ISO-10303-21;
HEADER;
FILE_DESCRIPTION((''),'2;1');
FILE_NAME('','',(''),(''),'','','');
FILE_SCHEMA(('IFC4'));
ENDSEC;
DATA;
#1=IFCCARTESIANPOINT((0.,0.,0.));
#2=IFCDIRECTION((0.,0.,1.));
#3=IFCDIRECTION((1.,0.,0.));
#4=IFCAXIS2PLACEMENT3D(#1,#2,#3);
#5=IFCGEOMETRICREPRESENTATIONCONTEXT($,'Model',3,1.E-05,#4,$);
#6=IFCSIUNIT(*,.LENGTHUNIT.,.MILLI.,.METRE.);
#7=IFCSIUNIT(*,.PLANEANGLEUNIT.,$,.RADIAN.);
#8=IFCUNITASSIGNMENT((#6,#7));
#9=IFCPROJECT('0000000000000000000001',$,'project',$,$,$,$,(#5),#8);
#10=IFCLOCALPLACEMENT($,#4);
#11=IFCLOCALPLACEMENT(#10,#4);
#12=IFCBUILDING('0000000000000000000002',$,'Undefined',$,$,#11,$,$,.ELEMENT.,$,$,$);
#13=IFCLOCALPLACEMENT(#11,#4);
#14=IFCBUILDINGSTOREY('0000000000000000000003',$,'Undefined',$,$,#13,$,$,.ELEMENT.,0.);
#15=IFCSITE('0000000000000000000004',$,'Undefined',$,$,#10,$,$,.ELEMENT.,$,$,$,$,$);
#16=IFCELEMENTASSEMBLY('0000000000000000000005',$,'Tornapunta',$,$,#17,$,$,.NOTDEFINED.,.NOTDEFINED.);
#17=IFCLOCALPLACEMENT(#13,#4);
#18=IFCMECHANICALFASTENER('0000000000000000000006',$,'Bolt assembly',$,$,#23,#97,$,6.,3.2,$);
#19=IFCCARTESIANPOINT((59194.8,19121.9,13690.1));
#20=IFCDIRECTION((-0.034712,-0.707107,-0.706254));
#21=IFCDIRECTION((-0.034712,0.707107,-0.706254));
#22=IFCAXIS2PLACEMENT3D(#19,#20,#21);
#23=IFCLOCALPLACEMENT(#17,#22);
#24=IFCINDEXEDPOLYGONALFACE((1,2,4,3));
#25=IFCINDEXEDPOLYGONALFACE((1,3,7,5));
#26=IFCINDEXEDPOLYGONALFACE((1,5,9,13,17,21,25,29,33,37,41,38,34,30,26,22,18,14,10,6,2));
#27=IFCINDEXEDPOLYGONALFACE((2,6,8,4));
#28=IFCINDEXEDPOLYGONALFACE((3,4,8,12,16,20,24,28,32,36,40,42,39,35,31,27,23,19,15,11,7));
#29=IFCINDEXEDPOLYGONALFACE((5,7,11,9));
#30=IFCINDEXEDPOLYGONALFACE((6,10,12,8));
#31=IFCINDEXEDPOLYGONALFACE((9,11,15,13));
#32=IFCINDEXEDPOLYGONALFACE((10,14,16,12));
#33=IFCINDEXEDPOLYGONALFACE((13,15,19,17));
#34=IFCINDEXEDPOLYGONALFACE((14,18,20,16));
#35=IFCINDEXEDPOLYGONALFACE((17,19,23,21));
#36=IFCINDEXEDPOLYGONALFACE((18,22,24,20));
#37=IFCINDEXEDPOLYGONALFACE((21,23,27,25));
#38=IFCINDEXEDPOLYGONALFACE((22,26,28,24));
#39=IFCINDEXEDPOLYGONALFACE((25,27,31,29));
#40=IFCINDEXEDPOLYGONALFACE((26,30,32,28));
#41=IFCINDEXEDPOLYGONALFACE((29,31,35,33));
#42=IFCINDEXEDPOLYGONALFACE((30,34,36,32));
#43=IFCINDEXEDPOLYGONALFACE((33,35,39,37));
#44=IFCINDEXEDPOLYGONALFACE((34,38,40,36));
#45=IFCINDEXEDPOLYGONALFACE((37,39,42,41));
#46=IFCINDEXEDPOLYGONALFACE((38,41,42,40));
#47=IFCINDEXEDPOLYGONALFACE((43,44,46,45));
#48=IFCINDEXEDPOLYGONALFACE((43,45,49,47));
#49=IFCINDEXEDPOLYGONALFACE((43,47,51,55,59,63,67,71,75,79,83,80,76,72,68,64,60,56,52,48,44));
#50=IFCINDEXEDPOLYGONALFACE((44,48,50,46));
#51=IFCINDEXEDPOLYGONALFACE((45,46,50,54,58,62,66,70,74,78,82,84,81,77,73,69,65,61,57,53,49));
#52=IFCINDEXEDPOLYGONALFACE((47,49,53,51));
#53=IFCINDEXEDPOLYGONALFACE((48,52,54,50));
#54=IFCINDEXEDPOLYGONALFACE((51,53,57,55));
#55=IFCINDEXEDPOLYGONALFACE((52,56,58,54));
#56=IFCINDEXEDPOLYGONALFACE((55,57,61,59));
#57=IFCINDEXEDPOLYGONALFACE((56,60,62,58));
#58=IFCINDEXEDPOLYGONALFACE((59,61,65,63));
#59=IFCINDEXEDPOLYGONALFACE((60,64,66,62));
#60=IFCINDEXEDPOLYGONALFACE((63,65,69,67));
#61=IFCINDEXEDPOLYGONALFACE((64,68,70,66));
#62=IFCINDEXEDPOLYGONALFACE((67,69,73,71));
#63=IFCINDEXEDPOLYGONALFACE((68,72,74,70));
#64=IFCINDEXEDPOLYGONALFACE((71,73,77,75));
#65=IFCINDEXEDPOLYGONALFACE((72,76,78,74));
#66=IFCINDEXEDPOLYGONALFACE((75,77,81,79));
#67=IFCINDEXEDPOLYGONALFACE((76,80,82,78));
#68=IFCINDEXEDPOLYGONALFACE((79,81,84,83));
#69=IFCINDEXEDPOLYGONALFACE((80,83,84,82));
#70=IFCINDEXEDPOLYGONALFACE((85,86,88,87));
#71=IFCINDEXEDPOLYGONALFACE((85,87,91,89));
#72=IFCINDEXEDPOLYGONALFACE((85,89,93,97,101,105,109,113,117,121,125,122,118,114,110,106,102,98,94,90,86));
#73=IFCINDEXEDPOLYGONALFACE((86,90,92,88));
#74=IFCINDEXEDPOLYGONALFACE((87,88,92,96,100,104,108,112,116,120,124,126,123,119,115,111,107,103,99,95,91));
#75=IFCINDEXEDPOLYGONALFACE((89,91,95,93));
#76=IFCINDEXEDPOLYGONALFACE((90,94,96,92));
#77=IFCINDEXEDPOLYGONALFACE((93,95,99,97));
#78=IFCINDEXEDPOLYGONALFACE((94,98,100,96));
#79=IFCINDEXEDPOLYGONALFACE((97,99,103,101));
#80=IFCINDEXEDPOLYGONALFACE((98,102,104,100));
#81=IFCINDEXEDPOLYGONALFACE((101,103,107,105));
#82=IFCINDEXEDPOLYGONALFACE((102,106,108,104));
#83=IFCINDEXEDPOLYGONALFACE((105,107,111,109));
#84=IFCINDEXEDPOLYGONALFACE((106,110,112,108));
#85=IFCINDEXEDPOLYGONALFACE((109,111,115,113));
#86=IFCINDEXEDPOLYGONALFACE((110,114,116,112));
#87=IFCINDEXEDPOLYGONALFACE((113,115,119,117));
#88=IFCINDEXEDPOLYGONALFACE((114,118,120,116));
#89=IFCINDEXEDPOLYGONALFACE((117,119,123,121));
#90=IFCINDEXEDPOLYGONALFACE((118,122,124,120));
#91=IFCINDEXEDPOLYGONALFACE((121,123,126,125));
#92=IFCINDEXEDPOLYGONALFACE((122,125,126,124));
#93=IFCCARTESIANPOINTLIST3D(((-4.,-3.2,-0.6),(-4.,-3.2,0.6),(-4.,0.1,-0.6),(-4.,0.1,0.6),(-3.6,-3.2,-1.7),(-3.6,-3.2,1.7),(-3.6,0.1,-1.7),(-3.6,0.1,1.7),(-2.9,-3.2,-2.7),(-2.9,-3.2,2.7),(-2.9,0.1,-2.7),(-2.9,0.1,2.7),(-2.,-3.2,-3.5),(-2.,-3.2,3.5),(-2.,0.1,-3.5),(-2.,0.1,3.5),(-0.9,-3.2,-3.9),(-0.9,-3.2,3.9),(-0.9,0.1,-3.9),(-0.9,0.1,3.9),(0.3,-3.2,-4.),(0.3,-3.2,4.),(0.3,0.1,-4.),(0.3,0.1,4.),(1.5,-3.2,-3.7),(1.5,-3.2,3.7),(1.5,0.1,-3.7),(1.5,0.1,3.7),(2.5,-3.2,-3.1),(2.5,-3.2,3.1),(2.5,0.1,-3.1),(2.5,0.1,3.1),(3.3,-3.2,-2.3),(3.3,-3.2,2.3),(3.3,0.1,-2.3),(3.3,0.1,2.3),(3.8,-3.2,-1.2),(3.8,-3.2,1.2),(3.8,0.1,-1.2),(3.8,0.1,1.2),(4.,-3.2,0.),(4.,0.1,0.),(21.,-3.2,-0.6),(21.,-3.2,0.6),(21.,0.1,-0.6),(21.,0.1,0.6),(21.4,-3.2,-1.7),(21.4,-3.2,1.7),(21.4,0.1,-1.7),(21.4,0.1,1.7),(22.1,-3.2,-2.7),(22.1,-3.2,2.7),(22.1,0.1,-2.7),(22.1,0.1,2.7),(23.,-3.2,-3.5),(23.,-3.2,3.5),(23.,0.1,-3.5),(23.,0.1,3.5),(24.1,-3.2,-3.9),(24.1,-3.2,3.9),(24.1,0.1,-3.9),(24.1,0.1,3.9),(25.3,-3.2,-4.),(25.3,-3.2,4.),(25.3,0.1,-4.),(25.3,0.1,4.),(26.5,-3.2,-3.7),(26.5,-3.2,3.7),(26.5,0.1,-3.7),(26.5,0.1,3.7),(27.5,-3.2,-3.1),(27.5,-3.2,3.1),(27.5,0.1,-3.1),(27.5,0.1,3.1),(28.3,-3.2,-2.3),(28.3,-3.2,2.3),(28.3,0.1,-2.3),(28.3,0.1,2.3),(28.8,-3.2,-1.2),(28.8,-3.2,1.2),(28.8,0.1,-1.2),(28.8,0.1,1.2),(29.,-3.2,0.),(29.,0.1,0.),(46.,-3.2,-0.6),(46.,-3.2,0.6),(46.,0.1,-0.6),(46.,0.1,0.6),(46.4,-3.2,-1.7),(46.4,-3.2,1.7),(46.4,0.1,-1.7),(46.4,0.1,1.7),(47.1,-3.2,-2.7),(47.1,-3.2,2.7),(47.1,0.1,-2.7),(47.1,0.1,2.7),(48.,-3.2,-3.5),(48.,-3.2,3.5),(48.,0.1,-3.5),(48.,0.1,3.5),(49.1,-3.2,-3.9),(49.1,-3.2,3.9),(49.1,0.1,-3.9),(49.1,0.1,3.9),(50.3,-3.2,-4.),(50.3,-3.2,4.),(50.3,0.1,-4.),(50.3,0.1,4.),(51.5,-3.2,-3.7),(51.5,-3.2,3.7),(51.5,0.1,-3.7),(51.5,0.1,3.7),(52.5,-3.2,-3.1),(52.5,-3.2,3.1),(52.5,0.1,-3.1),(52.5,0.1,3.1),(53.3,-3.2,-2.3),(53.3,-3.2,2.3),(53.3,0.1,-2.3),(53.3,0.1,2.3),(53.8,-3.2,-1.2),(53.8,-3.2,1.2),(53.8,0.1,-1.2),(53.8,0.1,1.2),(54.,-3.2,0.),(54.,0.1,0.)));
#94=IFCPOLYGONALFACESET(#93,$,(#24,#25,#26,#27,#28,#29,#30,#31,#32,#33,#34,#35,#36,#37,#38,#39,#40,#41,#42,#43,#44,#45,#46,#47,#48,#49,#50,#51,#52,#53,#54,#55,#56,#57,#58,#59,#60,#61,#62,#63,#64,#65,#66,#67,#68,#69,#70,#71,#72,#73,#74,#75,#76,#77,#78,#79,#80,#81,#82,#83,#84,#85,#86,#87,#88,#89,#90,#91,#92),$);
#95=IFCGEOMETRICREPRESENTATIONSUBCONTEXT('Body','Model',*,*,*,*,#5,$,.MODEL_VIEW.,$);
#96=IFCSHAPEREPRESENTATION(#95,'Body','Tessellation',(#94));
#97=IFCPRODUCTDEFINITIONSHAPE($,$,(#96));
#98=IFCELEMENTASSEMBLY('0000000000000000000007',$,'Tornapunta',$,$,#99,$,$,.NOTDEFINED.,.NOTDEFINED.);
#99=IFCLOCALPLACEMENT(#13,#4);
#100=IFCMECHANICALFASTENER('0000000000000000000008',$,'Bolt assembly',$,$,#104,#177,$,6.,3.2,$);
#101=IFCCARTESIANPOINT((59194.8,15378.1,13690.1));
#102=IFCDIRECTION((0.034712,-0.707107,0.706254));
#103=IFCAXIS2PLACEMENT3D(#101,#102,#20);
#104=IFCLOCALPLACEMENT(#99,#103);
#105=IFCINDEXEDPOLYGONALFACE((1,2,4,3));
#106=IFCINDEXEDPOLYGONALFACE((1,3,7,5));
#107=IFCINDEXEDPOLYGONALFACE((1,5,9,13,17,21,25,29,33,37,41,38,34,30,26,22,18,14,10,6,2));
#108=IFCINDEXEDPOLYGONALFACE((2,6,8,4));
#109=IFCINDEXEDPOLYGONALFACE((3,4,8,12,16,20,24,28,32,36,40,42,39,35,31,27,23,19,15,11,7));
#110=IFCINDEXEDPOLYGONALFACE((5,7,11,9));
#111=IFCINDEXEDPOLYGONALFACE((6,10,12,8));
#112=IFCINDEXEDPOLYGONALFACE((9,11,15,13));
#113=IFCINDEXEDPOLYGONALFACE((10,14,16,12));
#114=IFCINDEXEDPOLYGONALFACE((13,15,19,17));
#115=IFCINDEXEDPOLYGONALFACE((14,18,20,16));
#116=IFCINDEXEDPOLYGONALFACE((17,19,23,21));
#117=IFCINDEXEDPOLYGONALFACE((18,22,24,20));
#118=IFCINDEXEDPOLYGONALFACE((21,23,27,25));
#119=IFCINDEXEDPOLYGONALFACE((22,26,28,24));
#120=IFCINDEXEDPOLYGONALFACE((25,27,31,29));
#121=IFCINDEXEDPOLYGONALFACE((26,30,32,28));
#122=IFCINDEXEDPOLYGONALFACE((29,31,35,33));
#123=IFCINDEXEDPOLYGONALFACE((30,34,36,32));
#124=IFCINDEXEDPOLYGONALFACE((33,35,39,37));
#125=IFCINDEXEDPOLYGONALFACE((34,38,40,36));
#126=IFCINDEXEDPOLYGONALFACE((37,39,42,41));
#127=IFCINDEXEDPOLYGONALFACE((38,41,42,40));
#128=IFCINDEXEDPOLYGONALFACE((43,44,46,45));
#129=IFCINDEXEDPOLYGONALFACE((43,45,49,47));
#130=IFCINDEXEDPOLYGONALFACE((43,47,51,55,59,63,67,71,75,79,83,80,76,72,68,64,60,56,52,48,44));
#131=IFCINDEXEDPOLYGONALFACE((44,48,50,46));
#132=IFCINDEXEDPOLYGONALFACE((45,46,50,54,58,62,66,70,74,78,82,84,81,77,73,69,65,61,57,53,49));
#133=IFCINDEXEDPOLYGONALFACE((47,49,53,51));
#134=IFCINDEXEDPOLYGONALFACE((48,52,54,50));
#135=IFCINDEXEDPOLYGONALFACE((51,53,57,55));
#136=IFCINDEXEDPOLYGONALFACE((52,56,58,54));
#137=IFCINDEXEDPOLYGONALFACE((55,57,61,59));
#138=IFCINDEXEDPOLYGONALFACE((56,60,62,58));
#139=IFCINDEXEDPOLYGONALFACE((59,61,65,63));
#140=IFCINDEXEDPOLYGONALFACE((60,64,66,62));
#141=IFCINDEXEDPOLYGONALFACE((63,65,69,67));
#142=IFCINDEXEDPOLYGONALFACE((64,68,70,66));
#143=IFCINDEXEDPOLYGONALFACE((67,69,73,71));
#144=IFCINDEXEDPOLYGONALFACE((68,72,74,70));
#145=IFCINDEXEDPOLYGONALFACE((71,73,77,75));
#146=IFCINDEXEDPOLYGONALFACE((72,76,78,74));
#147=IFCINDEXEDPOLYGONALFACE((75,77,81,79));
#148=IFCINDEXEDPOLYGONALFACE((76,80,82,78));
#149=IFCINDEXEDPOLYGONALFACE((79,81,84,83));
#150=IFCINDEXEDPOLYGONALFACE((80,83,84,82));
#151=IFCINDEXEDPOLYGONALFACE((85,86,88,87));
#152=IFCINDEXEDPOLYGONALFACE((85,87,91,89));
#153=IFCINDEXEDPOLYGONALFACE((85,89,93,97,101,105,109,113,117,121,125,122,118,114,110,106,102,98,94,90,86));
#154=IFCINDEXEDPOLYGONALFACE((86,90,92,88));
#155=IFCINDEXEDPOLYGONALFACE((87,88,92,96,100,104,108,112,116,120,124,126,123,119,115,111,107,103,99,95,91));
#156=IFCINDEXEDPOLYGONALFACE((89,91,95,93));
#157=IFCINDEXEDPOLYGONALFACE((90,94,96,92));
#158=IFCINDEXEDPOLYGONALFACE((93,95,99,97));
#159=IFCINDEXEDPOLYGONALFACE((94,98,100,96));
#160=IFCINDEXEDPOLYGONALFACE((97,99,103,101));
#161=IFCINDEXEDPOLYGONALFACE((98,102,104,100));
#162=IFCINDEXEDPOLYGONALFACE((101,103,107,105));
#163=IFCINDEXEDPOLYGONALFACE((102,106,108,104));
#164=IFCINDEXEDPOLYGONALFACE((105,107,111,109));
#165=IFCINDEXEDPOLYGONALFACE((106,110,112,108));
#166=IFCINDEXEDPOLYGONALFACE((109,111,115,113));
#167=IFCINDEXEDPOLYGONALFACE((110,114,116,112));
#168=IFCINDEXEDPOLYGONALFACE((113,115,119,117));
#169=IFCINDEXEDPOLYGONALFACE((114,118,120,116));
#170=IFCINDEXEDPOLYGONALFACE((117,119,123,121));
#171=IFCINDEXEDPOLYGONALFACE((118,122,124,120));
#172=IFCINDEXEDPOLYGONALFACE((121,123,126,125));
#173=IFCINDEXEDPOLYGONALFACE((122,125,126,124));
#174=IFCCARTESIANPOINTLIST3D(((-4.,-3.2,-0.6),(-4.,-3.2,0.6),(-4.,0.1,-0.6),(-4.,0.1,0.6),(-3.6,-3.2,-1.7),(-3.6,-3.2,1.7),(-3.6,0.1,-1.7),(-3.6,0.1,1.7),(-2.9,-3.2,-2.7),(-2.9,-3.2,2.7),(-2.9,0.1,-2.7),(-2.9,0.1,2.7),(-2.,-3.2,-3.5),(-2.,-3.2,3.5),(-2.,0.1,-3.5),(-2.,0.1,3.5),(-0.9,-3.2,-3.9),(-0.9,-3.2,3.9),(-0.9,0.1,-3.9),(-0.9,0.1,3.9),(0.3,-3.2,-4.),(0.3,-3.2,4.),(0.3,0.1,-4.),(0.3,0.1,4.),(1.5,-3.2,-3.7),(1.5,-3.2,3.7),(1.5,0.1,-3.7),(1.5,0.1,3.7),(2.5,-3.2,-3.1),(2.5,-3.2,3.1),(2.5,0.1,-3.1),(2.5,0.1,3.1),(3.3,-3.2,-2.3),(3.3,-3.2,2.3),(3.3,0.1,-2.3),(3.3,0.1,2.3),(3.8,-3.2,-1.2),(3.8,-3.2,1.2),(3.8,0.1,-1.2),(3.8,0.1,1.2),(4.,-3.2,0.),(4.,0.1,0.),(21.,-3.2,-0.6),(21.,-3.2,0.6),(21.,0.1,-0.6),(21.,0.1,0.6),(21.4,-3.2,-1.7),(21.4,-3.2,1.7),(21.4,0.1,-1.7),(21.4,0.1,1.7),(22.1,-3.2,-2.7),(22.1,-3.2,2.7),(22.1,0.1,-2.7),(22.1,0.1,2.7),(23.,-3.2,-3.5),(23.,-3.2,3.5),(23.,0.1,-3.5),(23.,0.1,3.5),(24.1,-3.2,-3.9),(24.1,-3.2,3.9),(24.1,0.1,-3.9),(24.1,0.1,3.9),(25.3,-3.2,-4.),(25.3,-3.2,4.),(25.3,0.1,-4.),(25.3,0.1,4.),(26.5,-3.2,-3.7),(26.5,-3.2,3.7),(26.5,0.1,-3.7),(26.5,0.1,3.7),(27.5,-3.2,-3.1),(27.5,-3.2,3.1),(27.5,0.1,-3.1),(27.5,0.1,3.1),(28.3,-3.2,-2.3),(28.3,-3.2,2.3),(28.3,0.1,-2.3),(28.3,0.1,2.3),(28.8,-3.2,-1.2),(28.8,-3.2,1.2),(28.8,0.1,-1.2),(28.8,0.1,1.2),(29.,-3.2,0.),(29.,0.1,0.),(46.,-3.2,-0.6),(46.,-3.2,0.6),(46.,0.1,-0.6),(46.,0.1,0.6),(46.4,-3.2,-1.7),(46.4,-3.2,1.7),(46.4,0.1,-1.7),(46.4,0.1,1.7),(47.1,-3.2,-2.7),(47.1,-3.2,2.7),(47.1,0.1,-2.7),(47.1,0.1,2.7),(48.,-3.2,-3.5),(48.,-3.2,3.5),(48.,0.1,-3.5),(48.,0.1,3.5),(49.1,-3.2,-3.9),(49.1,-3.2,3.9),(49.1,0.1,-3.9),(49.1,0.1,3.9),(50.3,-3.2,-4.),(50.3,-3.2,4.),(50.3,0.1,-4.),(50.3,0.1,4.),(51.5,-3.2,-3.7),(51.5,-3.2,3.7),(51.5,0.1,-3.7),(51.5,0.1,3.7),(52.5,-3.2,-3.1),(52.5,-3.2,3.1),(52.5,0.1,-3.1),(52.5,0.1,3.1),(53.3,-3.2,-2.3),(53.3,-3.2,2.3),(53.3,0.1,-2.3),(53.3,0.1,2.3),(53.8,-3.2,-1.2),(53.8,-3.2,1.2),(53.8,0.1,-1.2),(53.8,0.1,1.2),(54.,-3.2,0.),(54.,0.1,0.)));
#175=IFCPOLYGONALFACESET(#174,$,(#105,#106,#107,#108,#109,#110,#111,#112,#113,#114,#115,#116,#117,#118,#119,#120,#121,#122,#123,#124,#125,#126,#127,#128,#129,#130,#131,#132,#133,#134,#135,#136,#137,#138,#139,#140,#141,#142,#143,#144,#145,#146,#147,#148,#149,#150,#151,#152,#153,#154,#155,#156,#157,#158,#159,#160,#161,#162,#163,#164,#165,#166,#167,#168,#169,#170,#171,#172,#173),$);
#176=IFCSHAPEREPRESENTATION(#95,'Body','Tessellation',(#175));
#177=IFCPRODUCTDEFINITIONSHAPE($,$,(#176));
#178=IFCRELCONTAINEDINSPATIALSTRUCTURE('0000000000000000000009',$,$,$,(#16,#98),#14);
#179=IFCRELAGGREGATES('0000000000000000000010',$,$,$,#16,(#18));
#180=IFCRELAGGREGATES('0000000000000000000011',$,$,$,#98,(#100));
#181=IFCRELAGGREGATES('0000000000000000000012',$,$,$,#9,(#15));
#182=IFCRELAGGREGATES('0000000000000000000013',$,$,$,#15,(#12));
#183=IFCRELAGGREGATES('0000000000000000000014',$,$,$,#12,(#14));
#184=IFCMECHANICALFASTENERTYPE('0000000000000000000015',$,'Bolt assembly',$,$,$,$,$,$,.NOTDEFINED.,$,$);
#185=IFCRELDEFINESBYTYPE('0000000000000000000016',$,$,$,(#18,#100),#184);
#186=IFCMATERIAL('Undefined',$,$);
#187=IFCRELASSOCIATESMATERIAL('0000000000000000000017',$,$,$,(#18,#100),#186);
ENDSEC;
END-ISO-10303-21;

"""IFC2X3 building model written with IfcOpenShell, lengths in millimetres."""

from ifc_helpers import new_model, si_unit, frame, origin_with_axes, origin_2d_with_axis, place, context, subcontext, project, spatial, circle, extrude, source, transform, mapped, material, type_object, element, aggregate, save


model = new_model("IFC2X3")

# Units and contexts
model_context = context("Model", 3, precision=1e-05, world=origin_with_axes())
body_context = subcontext(model_context, "Body", "Model", "MODEL_VIEW")
ifc_project = project(units=[si_unit("LENGTHUNIT", "METRE", prefix="MILLI"), si_unit("PLANEANGLEUNIT", "RADIAN")], contexts=[model_context])

# Site, building, storey
site_placement = place(None, origin_with_axes())
site = spatial("IfcSite", under=ifc_project, at=site_placement, Name="Undefined", CompositionType="ELEMENT")
building_placement = place(site_placement, origin_with_axes())
building = spatial("IfcBuilding", under=site, at=building_placement, Name="Undefined", CompositionType="ELEMENT")
storey_placement = place(building_placement, origin_with_axes())
storey = spatial("IfcBuildingStorey", under=building, at=storey_placement, Name="Undefined", CompositionType="ELEMENT", Elevation=0.0)

# Shared definitions
mechanical_fastener_type = type_object("IfcMechanicalFastenerType", Name="Bolt assembly")

# Element assemblies, mechanical fasteners
ifc_material_1 = material(Name="Undefined")
assembly_1_placement = place(storey_placement, origin_with_axes())
assembly_1 = element("IfcElementAssembly", 1, at=assembly_1_placement, inside=storey, Name="Tornapunta", AssemblyPlace="NOTDEFINED", PredefinedType="NOTDEFINED")
shared_shape_1 = source(origin_with_axes(), body_context, "Body", "SweptSolid", [
    extrude(circle(Radius=4.0, at=origin_2d_with_axis()), frame((0.0, -3.2, 0.0), z_axis=(0.0, 1.0, 0.0), x_axis=(1.0, 0.0, 0.0)), (0.0, 0.0, 1.0), 3.3),
])
mechanical_fastener_1_placement = place(assembly_1_placement, frame((59194.8, 19121.9, 13690.1), z_axis=(-0.034712, -0.707107, -0.706254), x_axis=(-0.034712, 0.707107, -0.706254)))
mechanical_fastener_1 = element("IfcMechanicalFastener", 2, at=mechanical_fastener_1_placement, type_object=mechanical_fastener_type, material=ifc_material_1, Name="Bolt assembly", NominalDiameter=6.0, NominalLength=3.2, context=body_context, shape_type="MappedRepresentation", body=[
    mapped(shared_shape_1, transform((0.0, 0.0, 0.0))),
    mapped(shared_shape_1, transform((25.0, 0.0, 0.0))),
    mapped(shared_shape_1, transform((50.0, 0.0, 0.0))),
])
aggregate(assembly_1, [mechanical_fastener_1])
assembly_2_placement = place(storey_placement, origin_with_axes())
assembly_2 = element("IfcElementAssembly", 3, at=assembly_2_placement, inside=storey, Name="Tornapunta", AssemblyPlace="NOTDEFINED", PredefinedType="NOTDEFINED")
mechanical_fastener_2_placement = place(assembly_2_placement, frame((59194.8, 15378.1, 13690.1), z_axis=(0.034712, -0.707107, 0.706254), x_axis=(-0.034712, -0.707107, -0.706254)))
mechanical_fastener_2 = element("IfcMechanicalFastener", 4, at=mechanical_fastener_2_placement, type_object=mechanical_fastener_type, material=ifc_material_1, Name="Bolt assembly", NominalDiameter=6.0, NominalLength=3.2, context=body_context, shape_type="MappedRepresentation", body=[
    mapped(shared_shape_1, transform((0.0, 0.0, 0.0))),
    mapped(shared_shape_1, transform((25.0, 0.0, 0.0))),
    mapped(shared_shape_1, transform((50.0, 0.0, 0.0))),
])
aggregate(assembly_2, [mechanical_fastener_2])

save(model, "model.ifc")
